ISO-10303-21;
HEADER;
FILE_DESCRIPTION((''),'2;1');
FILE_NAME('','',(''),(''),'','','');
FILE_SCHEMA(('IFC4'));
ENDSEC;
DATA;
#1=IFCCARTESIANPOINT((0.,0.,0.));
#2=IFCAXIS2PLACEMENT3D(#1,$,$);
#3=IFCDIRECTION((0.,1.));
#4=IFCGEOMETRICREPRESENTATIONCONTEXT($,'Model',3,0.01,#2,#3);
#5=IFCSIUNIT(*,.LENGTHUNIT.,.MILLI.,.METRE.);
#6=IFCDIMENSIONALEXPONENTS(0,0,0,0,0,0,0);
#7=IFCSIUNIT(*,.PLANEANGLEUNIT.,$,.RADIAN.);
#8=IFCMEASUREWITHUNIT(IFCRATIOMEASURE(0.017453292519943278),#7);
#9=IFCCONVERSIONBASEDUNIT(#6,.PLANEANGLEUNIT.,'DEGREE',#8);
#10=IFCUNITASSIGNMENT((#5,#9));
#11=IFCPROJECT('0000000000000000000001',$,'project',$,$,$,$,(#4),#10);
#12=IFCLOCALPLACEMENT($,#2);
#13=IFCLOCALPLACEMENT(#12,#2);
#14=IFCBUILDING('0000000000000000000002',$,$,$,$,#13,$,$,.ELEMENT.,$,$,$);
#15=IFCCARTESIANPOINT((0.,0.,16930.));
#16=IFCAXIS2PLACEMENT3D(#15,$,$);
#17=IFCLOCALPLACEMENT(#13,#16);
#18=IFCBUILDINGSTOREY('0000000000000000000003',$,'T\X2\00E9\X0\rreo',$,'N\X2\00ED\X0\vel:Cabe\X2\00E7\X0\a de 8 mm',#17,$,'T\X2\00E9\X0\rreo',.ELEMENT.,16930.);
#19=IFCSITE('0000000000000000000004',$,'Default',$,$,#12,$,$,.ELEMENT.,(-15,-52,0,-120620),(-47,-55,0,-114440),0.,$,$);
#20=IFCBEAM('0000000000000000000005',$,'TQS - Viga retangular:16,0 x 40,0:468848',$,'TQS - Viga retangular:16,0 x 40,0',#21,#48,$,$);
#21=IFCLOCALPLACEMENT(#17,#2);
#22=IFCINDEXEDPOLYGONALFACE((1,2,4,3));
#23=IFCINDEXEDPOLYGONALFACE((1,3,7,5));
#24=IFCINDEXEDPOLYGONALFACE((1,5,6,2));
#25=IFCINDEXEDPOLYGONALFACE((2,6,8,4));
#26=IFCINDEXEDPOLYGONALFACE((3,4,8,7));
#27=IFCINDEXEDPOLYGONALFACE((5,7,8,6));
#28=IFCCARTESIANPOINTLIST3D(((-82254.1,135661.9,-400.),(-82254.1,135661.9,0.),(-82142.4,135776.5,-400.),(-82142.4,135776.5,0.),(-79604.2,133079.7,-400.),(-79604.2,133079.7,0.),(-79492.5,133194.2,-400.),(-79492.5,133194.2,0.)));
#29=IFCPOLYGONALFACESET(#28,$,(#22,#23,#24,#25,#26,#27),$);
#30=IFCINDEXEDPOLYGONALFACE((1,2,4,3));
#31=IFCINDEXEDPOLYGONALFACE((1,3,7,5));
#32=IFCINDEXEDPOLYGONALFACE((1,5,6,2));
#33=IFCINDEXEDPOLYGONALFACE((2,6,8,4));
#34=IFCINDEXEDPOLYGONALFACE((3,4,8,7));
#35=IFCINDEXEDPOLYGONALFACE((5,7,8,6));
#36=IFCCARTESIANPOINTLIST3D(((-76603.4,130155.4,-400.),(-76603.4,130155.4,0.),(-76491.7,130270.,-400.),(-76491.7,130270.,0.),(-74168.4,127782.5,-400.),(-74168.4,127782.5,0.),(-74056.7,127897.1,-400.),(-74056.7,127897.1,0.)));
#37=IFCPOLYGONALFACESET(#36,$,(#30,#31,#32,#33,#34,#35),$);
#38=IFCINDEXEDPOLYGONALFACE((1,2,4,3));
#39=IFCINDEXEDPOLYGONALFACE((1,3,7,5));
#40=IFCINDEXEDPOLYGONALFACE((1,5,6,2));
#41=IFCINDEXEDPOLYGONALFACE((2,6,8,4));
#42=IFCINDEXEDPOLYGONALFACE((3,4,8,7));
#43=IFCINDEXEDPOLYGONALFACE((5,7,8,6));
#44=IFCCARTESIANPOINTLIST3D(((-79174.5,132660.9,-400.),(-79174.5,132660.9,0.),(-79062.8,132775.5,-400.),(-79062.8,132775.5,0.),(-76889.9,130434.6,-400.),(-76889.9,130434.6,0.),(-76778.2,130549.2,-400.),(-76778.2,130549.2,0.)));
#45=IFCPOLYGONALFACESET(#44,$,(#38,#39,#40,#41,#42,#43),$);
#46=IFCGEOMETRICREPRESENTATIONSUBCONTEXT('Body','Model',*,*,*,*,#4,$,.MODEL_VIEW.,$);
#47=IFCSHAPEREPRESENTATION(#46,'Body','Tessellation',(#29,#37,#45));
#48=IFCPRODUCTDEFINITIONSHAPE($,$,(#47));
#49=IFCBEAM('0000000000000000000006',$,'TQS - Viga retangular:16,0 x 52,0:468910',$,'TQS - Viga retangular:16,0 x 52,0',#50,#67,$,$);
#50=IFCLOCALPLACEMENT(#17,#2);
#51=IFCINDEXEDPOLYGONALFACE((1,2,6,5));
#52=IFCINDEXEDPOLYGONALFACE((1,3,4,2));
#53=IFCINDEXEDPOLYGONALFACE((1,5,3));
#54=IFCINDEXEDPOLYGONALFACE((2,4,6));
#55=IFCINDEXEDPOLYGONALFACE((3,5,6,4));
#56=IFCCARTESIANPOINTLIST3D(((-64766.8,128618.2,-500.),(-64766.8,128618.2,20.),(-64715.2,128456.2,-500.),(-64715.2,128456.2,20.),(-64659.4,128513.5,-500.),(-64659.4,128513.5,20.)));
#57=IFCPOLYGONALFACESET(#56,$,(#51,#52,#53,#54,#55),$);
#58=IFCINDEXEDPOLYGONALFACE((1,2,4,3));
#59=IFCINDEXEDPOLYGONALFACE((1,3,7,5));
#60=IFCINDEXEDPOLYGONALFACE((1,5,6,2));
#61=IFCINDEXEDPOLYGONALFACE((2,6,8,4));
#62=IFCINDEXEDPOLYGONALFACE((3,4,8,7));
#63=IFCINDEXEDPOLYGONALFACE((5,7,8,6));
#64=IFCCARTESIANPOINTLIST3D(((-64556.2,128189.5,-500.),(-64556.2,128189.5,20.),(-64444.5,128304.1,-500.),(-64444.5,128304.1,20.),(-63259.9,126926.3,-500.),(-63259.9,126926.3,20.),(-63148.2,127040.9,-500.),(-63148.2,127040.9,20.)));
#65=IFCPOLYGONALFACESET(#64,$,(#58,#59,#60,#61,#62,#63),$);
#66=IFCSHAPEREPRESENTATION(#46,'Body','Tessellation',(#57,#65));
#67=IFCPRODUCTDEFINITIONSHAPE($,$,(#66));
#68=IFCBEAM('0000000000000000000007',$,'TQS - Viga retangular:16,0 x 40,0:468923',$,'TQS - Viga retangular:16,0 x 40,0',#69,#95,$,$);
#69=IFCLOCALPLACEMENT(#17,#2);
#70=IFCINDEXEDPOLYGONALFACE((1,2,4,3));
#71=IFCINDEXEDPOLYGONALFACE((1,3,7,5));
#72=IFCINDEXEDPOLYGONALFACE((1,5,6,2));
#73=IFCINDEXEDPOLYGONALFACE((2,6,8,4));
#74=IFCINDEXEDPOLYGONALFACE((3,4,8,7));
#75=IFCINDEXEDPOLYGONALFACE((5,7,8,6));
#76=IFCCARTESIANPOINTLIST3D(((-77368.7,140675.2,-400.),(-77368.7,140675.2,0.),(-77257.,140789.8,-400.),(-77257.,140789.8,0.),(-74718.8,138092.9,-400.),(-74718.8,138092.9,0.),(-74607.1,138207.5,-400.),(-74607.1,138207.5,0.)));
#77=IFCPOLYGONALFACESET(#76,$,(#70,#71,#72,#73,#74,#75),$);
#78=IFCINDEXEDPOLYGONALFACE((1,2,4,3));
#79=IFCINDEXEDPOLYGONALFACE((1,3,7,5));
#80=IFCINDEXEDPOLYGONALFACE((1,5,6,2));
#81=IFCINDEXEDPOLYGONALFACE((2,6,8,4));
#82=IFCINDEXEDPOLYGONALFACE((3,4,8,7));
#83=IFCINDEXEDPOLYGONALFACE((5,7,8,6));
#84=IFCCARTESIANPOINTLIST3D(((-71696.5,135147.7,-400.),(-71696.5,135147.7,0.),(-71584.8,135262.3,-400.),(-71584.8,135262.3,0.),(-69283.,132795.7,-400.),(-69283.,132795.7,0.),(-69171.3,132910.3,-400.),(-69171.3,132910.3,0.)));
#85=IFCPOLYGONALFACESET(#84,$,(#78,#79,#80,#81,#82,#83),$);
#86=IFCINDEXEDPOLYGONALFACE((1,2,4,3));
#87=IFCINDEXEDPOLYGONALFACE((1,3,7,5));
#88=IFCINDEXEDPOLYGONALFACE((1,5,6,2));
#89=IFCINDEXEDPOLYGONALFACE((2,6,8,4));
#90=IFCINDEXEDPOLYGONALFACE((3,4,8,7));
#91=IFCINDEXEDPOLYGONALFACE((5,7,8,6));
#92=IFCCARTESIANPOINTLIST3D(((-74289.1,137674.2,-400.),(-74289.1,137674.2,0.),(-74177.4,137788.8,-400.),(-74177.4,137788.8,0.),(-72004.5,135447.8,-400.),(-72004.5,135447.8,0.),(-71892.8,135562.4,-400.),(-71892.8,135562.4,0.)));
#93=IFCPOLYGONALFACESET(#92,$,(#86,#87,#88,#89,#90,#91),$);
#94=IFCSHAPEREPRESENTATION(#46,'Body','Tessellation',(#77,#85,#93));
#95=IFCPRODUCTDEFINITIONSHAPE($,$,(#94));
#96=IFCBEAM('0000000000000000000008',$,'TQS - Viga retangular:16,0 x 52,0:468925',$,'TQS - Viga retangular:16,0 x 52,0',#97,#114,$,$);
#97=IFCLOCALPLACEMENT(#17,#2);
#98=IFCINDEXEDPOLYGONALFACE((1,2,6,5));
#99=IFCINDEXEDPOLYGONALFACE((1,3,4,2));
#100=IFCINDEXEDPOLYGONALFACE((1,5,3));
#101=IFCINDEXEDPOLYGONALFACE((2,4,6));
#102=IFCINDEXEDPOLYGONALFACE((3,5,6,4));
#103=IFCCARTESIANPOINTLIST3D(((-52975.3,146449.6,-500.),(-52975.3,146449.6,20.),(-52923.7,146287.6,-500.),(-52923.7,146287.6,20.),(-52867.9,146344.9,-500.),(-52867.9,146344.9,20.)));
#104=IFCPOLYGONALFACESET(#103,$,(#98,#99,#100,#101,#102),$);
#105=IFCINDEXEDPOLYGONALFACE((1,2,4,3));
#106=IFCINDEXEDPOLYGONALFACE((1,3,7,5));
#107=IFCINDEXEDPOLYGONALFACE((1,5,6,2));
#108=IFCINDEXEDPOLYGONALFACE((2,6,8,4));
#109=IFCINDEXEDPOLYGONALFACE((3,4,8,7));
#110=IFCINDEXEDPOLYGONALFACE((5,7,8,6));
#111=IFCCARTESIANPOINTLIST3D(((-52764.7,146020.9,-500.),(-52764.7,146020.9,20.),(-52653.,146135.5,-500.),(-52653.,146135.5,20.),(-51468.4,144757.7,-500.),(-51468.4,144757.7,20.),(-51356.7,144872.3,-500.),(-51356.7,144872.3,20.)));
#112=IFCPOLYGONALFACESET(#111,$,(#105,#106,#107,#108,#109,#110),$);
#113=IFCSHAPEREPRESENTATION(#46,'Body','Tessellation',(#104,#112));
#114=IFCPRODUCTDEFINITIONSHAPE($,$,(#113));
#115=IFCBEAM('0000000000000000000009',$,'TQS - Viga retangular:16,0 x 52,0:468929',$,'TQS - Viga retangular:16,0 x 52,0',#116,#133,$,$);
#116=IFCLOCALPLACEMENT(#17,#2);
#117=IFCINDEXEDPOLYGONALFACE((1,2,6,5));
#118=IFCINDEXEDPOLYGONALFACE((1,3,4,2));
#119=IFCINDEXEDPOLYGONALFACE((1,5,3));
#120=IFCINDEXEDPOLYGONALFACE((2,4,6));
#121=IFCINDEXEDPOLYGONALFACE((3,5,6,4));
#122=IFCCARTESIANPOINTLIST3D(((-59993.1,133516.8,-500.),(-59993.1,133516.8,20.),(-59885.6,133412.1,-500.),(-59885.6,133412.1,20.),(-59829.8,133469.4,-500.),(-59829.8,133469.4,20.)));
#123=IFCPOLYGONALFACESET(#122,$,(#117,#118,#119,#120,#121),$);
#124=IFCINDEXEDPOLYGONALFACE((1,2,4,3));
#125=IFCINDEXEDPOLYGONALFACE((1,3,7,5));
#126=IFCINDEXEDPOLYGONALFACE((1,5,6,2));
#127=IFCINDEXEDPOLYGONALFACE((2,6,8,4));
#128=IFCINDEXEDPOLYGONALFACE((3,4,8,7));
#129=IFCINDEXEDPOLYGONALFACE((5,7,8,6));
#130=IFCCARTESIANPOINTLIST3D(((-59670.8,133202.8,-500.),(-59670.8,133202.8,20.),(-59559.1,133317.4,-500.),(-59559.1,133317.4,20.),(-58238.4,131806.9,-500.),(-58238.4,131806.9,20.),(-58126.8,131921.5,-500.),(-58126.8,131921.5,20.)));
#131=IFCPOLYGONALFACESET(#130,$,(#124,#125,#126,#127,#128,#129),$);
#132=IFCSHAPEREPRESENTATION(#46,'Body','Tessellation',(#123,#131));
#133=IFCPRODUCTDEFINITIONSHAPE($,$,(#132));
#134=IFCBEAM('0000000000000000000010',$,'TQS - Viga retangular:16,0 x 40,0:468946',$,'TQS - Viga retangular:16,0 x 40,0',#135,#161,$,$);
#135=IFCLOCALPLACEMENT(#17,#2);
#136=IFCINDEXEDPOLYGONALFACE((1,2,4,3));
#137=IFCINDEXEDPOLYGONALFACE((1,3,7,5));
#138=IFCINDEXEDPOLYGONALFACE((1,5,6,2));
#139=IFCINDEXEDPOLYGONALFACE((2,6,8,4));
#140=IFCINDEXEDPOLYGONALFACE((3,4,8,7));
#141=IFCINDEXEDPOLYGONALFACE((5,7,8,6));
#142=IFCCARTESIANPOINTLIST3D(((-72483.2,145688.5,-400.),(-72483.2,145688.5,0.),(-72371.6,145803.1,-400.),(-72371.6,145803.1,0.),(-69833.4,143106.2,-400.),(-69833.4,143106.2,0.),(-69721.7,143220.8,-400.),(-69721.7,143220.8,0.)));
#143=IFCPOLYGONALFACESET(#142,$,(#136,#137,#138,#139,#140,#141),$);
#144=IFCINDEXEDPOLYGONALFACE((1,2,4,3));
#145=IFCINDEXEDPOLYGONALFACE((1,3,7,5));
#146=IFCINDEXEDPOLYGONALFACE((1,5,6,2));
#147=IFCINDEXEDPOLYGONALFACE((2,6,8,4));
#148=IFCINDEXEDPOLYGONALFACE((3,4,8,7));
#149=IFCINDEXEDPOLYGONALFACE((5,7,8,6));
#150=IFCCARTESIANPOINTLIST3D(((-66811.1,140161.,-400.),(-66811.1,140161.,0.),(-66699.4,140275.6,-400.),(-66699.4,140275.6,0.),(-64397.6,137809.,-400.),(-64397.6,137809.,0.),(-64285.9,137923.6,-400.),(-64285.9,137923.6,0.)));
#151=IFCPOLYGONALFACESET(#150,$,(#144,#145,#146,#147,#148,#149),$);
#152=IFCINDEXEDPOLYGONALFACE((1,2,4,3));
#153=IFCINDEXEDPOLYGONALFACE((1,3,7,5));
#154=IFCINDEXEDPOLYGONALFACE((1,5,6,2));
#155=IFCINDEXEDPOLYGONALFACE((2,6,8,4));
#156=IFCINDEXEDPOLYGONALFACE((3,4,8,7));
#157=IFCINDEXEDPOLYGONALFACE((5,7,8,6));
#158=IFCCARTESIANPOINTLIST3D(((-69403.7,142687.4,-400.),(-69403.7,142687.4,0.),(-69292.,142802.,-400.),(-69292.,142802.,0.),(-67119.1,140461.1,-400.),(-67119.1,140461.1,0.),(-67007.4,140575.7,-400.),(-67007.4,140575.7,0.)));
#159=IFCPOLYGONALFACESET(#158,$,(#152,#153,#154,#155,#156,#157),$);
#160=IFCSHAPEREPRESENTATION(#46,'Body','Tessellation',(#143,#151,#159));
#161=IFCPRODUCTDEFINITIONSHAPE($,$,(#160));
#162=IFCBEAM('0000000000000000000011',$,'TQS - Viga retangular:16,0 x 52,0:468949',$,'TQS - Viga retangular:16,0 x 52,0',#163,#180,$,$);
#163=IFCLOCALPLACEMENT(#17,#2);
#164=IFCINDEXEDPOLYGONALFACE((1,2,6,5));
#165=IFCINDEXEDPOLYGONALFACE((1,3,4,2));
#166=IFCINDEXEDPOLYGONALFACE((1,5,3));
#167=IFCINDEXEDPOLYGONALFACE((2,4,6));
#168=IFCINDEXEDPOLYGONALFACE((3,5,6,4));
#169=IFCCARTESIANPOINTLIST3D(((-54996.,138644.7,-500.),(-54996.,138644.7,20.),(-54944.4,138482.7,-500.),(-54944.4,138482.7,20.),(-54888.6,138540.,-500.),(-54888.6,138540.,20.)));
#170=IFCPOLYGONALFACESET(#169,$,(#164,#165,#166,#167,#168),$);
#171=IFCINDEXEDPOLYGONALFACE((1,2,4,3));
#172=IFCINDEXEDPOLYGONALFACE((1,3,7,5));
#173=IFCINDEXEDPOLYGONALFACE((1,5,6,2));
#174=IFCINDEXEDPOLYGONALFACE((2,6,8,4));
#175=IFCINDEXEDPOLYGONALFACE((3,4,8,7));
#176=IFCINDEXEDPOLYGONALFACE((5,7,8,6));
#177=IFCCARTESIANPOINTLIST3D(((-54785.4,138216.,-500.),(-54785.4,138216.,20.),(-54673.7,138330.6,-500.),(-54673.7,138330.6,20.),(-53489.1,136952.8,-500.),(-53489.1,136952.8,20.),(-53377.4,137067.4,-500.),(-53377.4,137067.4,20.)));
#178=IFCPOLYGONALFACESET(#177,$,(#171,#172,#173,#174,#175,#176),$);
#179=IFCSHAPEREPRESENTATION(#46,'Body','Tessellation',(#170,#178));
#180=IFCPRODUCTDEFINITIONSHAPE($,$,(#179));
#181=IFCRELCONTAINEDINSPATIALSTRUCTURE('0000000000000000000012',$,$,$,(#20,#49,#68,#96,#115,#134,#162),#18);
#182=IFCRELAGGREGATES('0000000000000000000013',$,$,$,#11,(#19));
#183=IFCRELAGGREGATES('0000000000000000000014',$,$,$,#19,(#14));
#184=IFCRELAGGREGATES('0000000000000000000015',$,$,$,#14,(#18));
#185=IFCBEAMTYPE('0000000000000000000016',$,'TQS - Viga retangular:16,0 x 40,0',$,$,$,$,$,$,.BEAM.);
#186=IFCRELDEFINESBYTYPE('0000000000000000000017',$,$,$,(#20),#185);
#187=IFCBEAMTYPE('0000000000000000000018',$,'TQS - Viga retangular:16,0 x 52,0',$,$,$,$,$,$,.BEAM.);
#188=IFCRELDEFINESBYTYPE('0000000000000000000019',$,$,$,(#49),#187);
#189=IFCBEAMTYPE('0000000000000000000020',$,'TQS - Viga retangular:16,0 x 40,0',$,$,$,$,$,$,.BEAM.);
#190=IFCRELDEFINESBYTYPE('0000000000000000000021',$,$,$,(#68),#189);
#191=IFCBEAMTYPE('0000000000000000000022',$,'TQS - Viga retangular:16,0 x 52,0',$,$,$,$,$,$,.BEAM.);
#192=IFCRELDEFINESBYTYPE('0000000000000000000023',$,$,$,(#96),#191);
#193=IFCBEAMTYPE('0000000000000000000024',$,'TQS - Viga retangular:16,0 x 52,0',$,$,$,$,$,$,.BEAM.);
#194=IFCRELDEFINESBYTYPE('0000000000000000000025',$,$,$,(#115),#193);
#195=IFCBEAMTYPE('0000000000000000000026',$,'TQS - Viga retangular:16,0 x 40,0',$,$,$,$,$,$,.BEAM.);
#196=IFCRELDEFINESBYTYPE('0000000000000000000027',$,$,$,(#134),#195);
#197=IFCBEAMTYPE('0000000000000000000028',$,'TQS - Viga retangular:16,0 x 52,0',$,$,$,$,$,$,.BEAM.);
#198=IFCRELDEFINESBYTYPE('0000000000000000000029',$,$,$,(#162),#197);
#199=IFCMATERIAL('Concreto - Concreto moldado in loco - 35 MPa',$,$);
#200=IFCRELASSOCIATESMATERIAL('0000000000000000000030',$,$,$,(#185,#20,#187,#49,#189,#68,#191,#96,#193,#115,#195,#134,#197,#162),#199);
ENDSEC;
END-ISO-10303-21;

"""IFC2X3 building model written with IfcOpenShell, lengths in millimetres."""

from ifc_helpers import new_model, entity, si_unit, converted_unit, direction, frame, frame_2d, origin, place, context, subcontext, project, spatial, rectangle, extrude, clip, halfspace, source, transform, mapped, material, type_object, type_shapes, element, save


model = new_model("IFC2X3")

# Units and contexts
model_context = context("Model", 3, precision=0.01, world=origin(), true_north=direction((0.0, 1.0)))
body_context = subcontext(model_context, "Body", "Model", "MODEL_VIEW")
ifc_project = project(units=[si_unit("LENGTHUNIT", "METRE", prefix="MILLI"), converted_unit("PLANEANGLEUNIT", "DEGREE", entity("IfcRatioMeasure", 0.017453292519943278), si_unit("PLANEANGLEUNIT", "RADIAN"), dimensions=[0, 0, 0, 0, 0, 0, 0])], contexts=[model_context])

# Site, building, storey
site_placement = place(None, origin())
site = spatial("IfcSite", under=ifc_project, at=site_placement, Name="Default", CompositionType="ELEMENT", RefLatitude=(-15, -52, 0, -120620), RefLongitude=(-47, -55, 0, -114440), RefElevation=0.0)
building_placement = place(site_placement, origin())
building = spatial("IfcBuilding", under=site, at=building_placement, CompositionType="ELEMENT")
storey_placement = place(building_placement, frame((0.0, 0.0, 16930.0)))
storey = spatial("IfcBuildingStorey", under=building, at=storey_placement, Name="Térreo", ObjectType="Nível:Cabeça de 8 mm", LongName="Térreo", CompositionType="ELEMENT", Elevation=16930.0)

# Beams
ifc_material = material(Name="Concreto - Concreto moldado in loco - 35 MPa")
beam_type_1 = type_object("IfcBeamType", Name="TQS - Viga retangular:16,0 x 40,0", PredefinedType="BEAM", material=ifc_material)
shared_shape_1 = source(origin(), body_context, "Body", "SweptSolid", [
    extrude(rectangle(XDim=400.0, YDim=160.0, at=frame_2d((0.0, 0.0), x_axis=(1.0, 0.0))), frame((-79548.4, 133137.0, 16730.0), z_axis=(-0.71618, 0.697915, 0.0), x_axis=(0.0, 0.0, 1.0)), (0.0, 0.0, 1.0), 3700.0),
    extrude(rectangle(XDim=400.0, YDim=160.0, at=frame_2d((0.0, 0.0), x_axis=(1.0, 0.0))), frame((-74112.6, 127839.8, 16730.0), z_axis=(-0.71618, 0.697915, 0.0), x_axis=(0.0, 0.0, 1.0)), (0.0, 0.0, 1.0), 3400.0),
    extrude(rectangle(XDim=400.0, YDim=160.0, at=frame_2d((0.0, 0.0), x_axis=(1.0, 0.0))), frame((-76834.0, 130491.9, 16730.0), z_axis=(-0.71618, 0.697915, 0.0), x_axis=(0.0, 0.0, 1.0)), (0.0, 0.0, 1.0), 3190.0),
])
type_shapes(beam_type_1, [shared_shape_1])
beam_1_placement = place(storey_placement, frame((0.0, 0.0, -16930.0)))
element("IfcBeam", 1, at=beam_1_placement, inside=storey, type_object=beam_type_1, material=ifc_material, Name="TQS - Viga retangular:16,0 x 40,0:468848", ObjectType="TQS - Viga retangular:16,0 x 40,0", context=body_context, shape_type="MappedRepresentation", body=[
    mapped(shared_shape_1, transform((0.0, 0.0, 0.0), scale=1.0)),
])
beam_type_2 = type_object("IfcBeamType", Name="TQS - Viga retangular:16,0 x 52,0", PredefinedType="BEAM", material=ifc_material)
shared_shape_2 = source(origin(), body_context, "Body", "SweptSolid", [
    clip(extrude(rectangle(XDim=520.0, YDim=80.0, at=frame_2d((0.0, 0.0), x_axis=(0.0, 1.0))), frame((-64687.3, 128484.8, 16690.0), z_axis=(-0.71618, 0.697915, 0.0), x_axis=(0.697915, 0.71618, 0.0)), (0.0, 0.0, 1.0), 150.0), halfspace(frame((-64663.6, 128294.2, 16950.0), z_axis=(-0.952834, -0.303493, 0.0), x_axis=(0.303493, -0.952834, 0.0)), False)),
    extrude(rectangle(XDim=520.0, YDim=160.0, at=frame_2d((0.0, 0.0), x_axis=(1.0, 0.0))), frame((-63204.1, 126983.6, 16690.0), z_axis=(-0.71618, 0.697915, 0.0), x_axis=(0.0, 0.0, 1.0)), (0.0, 0.0, 1.0), 1810.0),
])
type_shapes(beam_type_2, [shared_shape_2])
beam_2_placement = place(storey_placement, frame((0.0, 0.0, -16930.0)))
element("IfcBeam", 2, at=beam_2_placement, inside=storey, type_object=beam_type_2, material=ifc_material, Name="TQS - Viga retangular:16,0 x 52,0:468910", ObjectType="TQS - Viga retangular:16,0 x 52,0", context=body_context, shape_type="MappedRepresentation", body=[
    mapped(shared_shape_2, transform((0.0, 0.0, 0.0), scale=1.0)),
])
beam_type_3 = type_object("IfcBeamType", Name="TQS - Viga retangular:16,0 x 40,0", PredefinedType="BEAM", material=ifc_material)
shared_shape_3 = source(origin(), body_context, "Body", "SweptSolid", [
    extrude(rectangle(XDim=400.0, YDim=160.0, at=frame_2d((0.0, 0.0), x_axis=(1.0, 0.0))), frame((-74663.0, 138150.2, 16730.0), z_axis=(-0.71618, 0.697915, 0.0), x_axis=(0.0, 0.0, 1.0)), (0.0, 0.0, 1.0), 3700.0),
    extrude(rectangle(XDim=400.0, YDim=160.0, at=frame_2d((0.0, 0.0), x_axis=(1.0, 0.0))), frame((-69227.1, 132853.0, 16730.0), z_axis=(-0.71618, 0.697915, 0.0), x_axis=(0.0, 0.0, 1.0)), (0.0, 0.0, 1.0), 3370.0),
    extrude(rectangle(XDim=400.0, YDim=160.0, at=frame_2d((0.0, 0.0), x_axis=(1.0, 0.0))), frame((-71948.6, 135505.1, 16730.0), z_axis=(-0.71618, 0.697915, 0.0), x_axis=(0.0, 0.0, 1.0)), (0.0, 0.0, 1.0), 3190.0),
])
type_shapes(beam_type_3, [shared_shape_3])
beam_3_placement = place(storey_placement, frame((0.0, 0.0, -16930.0)))
element("IfcBeam", 3, at=beam_3_placement, inside=storey, type_object=beam_type_3, material=ifc_material, Name="TQS - Viga retangular:16,0 x 40,0:468923", ObjectType="TQS - Viga retangular:16,0 x 40,0", context=body_context, shape_type="MappedRepresentation", body=[
    mapped(shared_shape_3, transform((0.0, 0.0, 0.0), scale=1.0)),
])
beam_type_4 = type_object("IfcBeamType", Name="TQS - Viga retangular:16,0 x 52,0", PredefinedType="BEAM", material=ifc_material)
shared_shape_4 = source(origin(), body_context, "Body", "SweptSolid", [
    clip(extrude(rectangle(XDim=520.0, YDim=80.0, at=frame_2d((0.0, 0.0), x_axis=(0.0, 1.0))), frame((-52895.8, 146316.3, 16690.0), z_axis=(-0.71618, 0.697915, 0.0), x_axis=(0.697915, 0.71618, 0.0)), (0.0, 0.0, 1.0), 150.0), halfspace(frame((-52872.1, 146125.6, 16950.0), z_axis=(-0.952834, -0.303493, 0.0), x_axis=(0.303493, -0.952834, 0.0)), False)),
    extrude(rectangle(XDim=520.0, YDim=160.0, at=frame_2d((0.0, 0.0), x_axis=(1.0, 0.0))), frame((-51412.6, 144815.0, 16690.0), z_axis=(-0.71618, 0.697915, 0.0), x_axis=(0.0, 0.0, 1.0)), (0.0, 0.0, 1.0), 1810.0),
])
type_shapes(beam_type_4, [shared_shape_4])
beam_4_placement = place(storey_placement, frame((0.0, 0.0, -16930.0)))
element("IfcBeam", 4, at=beam_4_placement, inside=storey, type_object=beam_type_4, material=ifc_material, Name="TQS - Viga retangular:16,0 x 52,0:468925", ObjectType="TQS - Viga retangular:16,0 x 52,0", context=body_context, shape_type="MappedRepresentation", body=[
    mapped(shared_shape_4, transform((0.0, 0.0, 0.0), scale=1.0)),
])
beam_type_5 = type_object("IfcBeamType", Name="TQS - Viga retangular:16,0 x 52,0", PredefinedType="BEAM", material=ifc_material)
shared_shape_5 = source(origin(), body_context, "Body", "SweptSolid", [
    clip(extrude(rectangle(XDim=520.0, YDim=80.0, at=frame_2d((0.0, 0.0), x_axis=(1.0, 0.0))), frame((-59857.7, 133440.8, 16690.0), z_axis=(-0.71618, 0.697915, 0.0), x_axis=(0.0, 0.0, 1.0)), (0.0, 0.0, 1.0), 150.0), halfspace(frame((-59666.5, 133422.0, 16950.0), z_axis=(0.278782, 0.960354, 0.0), x_axis=(0.960354, -0.278782, 0.0)), False)),
    extrude(rectangle(XDim=520.0, YDim=160.0, at=frame_2d((0.0, 0.0), x_axis=(1.0, 0.0))), frame((-58182.6, 131864.2, 16690.0), z_axis=(-0.71618, 0.697915, 0.0), x_axis=(0.0, 0.0, 1.0)), (0.0, 0.0, 1.0), 2000.0),
])
type_shapes(beam_type_5, [shared_shape_5])
beam_5_placement = place(storey_placement, frame((0.0, 0.0, -16930.0)))
element("IfcBeam", 5, at=beam_5_placement, inside=storey, type_object=beam_type_5, material=ifc_material, Name="TQS - Viga retangular:16,0 x 52,0:468929", ObjectType="TQS - Viga retangular:16,0 x 52,0", context=body_context, shape_type="MappedRepresentation", body=[
    mapped(shared_shape_5, transform((0.0, 0.0, 0.0), scale=1.0)),
])
beam_type_6 = type_object("IfcBeamType", Name="TQS - Viga retangular:16,0 x 40,0", PredefinedType="BEAM", material=ifc_material)
shared_shape_6 = source(origin(), body_context, "Body", "SweptSolid", [
    extrude(rectangle(XDim=400.0, YDim=160.0, at=frame_2d((0.0, 0.0), x_axis=(1.0, 0.0))), frame((-69777.5, 143163.5, 16730.0), z_axis=(-0.71618, 0.697915, 0.0), x_axis=(0.0, 0.0, 1.0)), (0.0, 0.0, 1.0), 3700.0),
    extrude(rectangle(XDim=400.0, YDim=160.0, at=frame_2d((0.0, 0.0), x_axis=(1.0, 0.0))), frame((-64341.7, 137866.3, 16730.0), z_axis=(-0.71618, 0.697915, 0.0), x_axis=(0.0, 0.0, 1.0)), (0.0, 0.0, 1.0), 3370.0),
    extrude(rectangle(XDim=400.0, YDim=160.0, at=frame_2d((0.0, 0.0), x_axis=(1.0, 0.0))), frame((-67063.2, 140518.4, 16730.0), z_axis=(-0.71618, 0.697915, 0.0), x_axis=(0.0, 0.0, 1.0)), (0.0, 0.0, 1.0), 3190.0),
])
type_shapes(beam_type_6, [shared_shape_6])
beam_6_placement = place(storey_placement, frame((0.0, 0.0, -16930.0)))
element("IfcBeam", 6, at=beam_6_placement, inside=storey, type_object=beam_type_6, material=ifc_material, Name="TQS - Viga retangular:16,0 x 40,0:468946", ObjectType="TQS - Viga retangular:16,0 x 40,0", context=body_context, shape_type="MappedRepresentation", body=[
    mapped(shared_shape_6, transform((0.0, 0.0, 0.0), scale=1.0)),
])
beam_type_7 = type_object("IfcBeamType", Name="TQS - Viga retangular:16,0 x 52,0", PredefinedType="BEAM", material=ifc_material)
shared_shape_7 = source(origin(), body_context, "Body", "SweptSolid", [
    clip(extrude(rectangle(XDim=520.0, YDim=80.0, at=frame_2d((0.0, 0.0), x_axis=(0.0, 1.0))), frame((-54916.5, 138511.3, 16690.0), z_axis=(-0.71618, 0.697915, 0.0), x_axis=(0.697915, 0.71618, 0.0)), (0.0, 0.0, 1.0), 150.0), halfspace(frame((-54892.8, 138320.7, 16950.0), z_axis=(-0.952834, -0.303493, 0.0), x_axis=(0.303493, -0.952834, 0.0)), False)),
    extrude(rectangle(XDim=520.0, YDim=160.0, at=frame_2d((0.0, 0.0), x_axis=(1.0, 0.0))), frame((-53433.3, 137010.1, 16690.0), z_axis=(-0.71618, 0.697915, 0.0), x_axis=(0.0, 0.0, 1.0)), (0.0, 0.0, 1.0), 1810.0),
])
type_shapes(beam_type_7, [shared_shape_7])
beam_7_placement = place(storey_placement, frame((0.0, 0.0, -16930.0)))
element("IfcBeam", 7, at=beam_7_placement, inside=storey, type_object=beam_type_7, material=ifc_material, Name="TQS - Viga retangular:16,0 x 52,0:468949", ObjectType="TQS - Viga retangular:16,0 x 52,0", context=body_context, shape_type="MappedRepresentation", body=[
    mapped(shared_shape_7, transform((0.0, 0.0, 0.0), scale=1.0)),
])

save(model, "model.ifc")
